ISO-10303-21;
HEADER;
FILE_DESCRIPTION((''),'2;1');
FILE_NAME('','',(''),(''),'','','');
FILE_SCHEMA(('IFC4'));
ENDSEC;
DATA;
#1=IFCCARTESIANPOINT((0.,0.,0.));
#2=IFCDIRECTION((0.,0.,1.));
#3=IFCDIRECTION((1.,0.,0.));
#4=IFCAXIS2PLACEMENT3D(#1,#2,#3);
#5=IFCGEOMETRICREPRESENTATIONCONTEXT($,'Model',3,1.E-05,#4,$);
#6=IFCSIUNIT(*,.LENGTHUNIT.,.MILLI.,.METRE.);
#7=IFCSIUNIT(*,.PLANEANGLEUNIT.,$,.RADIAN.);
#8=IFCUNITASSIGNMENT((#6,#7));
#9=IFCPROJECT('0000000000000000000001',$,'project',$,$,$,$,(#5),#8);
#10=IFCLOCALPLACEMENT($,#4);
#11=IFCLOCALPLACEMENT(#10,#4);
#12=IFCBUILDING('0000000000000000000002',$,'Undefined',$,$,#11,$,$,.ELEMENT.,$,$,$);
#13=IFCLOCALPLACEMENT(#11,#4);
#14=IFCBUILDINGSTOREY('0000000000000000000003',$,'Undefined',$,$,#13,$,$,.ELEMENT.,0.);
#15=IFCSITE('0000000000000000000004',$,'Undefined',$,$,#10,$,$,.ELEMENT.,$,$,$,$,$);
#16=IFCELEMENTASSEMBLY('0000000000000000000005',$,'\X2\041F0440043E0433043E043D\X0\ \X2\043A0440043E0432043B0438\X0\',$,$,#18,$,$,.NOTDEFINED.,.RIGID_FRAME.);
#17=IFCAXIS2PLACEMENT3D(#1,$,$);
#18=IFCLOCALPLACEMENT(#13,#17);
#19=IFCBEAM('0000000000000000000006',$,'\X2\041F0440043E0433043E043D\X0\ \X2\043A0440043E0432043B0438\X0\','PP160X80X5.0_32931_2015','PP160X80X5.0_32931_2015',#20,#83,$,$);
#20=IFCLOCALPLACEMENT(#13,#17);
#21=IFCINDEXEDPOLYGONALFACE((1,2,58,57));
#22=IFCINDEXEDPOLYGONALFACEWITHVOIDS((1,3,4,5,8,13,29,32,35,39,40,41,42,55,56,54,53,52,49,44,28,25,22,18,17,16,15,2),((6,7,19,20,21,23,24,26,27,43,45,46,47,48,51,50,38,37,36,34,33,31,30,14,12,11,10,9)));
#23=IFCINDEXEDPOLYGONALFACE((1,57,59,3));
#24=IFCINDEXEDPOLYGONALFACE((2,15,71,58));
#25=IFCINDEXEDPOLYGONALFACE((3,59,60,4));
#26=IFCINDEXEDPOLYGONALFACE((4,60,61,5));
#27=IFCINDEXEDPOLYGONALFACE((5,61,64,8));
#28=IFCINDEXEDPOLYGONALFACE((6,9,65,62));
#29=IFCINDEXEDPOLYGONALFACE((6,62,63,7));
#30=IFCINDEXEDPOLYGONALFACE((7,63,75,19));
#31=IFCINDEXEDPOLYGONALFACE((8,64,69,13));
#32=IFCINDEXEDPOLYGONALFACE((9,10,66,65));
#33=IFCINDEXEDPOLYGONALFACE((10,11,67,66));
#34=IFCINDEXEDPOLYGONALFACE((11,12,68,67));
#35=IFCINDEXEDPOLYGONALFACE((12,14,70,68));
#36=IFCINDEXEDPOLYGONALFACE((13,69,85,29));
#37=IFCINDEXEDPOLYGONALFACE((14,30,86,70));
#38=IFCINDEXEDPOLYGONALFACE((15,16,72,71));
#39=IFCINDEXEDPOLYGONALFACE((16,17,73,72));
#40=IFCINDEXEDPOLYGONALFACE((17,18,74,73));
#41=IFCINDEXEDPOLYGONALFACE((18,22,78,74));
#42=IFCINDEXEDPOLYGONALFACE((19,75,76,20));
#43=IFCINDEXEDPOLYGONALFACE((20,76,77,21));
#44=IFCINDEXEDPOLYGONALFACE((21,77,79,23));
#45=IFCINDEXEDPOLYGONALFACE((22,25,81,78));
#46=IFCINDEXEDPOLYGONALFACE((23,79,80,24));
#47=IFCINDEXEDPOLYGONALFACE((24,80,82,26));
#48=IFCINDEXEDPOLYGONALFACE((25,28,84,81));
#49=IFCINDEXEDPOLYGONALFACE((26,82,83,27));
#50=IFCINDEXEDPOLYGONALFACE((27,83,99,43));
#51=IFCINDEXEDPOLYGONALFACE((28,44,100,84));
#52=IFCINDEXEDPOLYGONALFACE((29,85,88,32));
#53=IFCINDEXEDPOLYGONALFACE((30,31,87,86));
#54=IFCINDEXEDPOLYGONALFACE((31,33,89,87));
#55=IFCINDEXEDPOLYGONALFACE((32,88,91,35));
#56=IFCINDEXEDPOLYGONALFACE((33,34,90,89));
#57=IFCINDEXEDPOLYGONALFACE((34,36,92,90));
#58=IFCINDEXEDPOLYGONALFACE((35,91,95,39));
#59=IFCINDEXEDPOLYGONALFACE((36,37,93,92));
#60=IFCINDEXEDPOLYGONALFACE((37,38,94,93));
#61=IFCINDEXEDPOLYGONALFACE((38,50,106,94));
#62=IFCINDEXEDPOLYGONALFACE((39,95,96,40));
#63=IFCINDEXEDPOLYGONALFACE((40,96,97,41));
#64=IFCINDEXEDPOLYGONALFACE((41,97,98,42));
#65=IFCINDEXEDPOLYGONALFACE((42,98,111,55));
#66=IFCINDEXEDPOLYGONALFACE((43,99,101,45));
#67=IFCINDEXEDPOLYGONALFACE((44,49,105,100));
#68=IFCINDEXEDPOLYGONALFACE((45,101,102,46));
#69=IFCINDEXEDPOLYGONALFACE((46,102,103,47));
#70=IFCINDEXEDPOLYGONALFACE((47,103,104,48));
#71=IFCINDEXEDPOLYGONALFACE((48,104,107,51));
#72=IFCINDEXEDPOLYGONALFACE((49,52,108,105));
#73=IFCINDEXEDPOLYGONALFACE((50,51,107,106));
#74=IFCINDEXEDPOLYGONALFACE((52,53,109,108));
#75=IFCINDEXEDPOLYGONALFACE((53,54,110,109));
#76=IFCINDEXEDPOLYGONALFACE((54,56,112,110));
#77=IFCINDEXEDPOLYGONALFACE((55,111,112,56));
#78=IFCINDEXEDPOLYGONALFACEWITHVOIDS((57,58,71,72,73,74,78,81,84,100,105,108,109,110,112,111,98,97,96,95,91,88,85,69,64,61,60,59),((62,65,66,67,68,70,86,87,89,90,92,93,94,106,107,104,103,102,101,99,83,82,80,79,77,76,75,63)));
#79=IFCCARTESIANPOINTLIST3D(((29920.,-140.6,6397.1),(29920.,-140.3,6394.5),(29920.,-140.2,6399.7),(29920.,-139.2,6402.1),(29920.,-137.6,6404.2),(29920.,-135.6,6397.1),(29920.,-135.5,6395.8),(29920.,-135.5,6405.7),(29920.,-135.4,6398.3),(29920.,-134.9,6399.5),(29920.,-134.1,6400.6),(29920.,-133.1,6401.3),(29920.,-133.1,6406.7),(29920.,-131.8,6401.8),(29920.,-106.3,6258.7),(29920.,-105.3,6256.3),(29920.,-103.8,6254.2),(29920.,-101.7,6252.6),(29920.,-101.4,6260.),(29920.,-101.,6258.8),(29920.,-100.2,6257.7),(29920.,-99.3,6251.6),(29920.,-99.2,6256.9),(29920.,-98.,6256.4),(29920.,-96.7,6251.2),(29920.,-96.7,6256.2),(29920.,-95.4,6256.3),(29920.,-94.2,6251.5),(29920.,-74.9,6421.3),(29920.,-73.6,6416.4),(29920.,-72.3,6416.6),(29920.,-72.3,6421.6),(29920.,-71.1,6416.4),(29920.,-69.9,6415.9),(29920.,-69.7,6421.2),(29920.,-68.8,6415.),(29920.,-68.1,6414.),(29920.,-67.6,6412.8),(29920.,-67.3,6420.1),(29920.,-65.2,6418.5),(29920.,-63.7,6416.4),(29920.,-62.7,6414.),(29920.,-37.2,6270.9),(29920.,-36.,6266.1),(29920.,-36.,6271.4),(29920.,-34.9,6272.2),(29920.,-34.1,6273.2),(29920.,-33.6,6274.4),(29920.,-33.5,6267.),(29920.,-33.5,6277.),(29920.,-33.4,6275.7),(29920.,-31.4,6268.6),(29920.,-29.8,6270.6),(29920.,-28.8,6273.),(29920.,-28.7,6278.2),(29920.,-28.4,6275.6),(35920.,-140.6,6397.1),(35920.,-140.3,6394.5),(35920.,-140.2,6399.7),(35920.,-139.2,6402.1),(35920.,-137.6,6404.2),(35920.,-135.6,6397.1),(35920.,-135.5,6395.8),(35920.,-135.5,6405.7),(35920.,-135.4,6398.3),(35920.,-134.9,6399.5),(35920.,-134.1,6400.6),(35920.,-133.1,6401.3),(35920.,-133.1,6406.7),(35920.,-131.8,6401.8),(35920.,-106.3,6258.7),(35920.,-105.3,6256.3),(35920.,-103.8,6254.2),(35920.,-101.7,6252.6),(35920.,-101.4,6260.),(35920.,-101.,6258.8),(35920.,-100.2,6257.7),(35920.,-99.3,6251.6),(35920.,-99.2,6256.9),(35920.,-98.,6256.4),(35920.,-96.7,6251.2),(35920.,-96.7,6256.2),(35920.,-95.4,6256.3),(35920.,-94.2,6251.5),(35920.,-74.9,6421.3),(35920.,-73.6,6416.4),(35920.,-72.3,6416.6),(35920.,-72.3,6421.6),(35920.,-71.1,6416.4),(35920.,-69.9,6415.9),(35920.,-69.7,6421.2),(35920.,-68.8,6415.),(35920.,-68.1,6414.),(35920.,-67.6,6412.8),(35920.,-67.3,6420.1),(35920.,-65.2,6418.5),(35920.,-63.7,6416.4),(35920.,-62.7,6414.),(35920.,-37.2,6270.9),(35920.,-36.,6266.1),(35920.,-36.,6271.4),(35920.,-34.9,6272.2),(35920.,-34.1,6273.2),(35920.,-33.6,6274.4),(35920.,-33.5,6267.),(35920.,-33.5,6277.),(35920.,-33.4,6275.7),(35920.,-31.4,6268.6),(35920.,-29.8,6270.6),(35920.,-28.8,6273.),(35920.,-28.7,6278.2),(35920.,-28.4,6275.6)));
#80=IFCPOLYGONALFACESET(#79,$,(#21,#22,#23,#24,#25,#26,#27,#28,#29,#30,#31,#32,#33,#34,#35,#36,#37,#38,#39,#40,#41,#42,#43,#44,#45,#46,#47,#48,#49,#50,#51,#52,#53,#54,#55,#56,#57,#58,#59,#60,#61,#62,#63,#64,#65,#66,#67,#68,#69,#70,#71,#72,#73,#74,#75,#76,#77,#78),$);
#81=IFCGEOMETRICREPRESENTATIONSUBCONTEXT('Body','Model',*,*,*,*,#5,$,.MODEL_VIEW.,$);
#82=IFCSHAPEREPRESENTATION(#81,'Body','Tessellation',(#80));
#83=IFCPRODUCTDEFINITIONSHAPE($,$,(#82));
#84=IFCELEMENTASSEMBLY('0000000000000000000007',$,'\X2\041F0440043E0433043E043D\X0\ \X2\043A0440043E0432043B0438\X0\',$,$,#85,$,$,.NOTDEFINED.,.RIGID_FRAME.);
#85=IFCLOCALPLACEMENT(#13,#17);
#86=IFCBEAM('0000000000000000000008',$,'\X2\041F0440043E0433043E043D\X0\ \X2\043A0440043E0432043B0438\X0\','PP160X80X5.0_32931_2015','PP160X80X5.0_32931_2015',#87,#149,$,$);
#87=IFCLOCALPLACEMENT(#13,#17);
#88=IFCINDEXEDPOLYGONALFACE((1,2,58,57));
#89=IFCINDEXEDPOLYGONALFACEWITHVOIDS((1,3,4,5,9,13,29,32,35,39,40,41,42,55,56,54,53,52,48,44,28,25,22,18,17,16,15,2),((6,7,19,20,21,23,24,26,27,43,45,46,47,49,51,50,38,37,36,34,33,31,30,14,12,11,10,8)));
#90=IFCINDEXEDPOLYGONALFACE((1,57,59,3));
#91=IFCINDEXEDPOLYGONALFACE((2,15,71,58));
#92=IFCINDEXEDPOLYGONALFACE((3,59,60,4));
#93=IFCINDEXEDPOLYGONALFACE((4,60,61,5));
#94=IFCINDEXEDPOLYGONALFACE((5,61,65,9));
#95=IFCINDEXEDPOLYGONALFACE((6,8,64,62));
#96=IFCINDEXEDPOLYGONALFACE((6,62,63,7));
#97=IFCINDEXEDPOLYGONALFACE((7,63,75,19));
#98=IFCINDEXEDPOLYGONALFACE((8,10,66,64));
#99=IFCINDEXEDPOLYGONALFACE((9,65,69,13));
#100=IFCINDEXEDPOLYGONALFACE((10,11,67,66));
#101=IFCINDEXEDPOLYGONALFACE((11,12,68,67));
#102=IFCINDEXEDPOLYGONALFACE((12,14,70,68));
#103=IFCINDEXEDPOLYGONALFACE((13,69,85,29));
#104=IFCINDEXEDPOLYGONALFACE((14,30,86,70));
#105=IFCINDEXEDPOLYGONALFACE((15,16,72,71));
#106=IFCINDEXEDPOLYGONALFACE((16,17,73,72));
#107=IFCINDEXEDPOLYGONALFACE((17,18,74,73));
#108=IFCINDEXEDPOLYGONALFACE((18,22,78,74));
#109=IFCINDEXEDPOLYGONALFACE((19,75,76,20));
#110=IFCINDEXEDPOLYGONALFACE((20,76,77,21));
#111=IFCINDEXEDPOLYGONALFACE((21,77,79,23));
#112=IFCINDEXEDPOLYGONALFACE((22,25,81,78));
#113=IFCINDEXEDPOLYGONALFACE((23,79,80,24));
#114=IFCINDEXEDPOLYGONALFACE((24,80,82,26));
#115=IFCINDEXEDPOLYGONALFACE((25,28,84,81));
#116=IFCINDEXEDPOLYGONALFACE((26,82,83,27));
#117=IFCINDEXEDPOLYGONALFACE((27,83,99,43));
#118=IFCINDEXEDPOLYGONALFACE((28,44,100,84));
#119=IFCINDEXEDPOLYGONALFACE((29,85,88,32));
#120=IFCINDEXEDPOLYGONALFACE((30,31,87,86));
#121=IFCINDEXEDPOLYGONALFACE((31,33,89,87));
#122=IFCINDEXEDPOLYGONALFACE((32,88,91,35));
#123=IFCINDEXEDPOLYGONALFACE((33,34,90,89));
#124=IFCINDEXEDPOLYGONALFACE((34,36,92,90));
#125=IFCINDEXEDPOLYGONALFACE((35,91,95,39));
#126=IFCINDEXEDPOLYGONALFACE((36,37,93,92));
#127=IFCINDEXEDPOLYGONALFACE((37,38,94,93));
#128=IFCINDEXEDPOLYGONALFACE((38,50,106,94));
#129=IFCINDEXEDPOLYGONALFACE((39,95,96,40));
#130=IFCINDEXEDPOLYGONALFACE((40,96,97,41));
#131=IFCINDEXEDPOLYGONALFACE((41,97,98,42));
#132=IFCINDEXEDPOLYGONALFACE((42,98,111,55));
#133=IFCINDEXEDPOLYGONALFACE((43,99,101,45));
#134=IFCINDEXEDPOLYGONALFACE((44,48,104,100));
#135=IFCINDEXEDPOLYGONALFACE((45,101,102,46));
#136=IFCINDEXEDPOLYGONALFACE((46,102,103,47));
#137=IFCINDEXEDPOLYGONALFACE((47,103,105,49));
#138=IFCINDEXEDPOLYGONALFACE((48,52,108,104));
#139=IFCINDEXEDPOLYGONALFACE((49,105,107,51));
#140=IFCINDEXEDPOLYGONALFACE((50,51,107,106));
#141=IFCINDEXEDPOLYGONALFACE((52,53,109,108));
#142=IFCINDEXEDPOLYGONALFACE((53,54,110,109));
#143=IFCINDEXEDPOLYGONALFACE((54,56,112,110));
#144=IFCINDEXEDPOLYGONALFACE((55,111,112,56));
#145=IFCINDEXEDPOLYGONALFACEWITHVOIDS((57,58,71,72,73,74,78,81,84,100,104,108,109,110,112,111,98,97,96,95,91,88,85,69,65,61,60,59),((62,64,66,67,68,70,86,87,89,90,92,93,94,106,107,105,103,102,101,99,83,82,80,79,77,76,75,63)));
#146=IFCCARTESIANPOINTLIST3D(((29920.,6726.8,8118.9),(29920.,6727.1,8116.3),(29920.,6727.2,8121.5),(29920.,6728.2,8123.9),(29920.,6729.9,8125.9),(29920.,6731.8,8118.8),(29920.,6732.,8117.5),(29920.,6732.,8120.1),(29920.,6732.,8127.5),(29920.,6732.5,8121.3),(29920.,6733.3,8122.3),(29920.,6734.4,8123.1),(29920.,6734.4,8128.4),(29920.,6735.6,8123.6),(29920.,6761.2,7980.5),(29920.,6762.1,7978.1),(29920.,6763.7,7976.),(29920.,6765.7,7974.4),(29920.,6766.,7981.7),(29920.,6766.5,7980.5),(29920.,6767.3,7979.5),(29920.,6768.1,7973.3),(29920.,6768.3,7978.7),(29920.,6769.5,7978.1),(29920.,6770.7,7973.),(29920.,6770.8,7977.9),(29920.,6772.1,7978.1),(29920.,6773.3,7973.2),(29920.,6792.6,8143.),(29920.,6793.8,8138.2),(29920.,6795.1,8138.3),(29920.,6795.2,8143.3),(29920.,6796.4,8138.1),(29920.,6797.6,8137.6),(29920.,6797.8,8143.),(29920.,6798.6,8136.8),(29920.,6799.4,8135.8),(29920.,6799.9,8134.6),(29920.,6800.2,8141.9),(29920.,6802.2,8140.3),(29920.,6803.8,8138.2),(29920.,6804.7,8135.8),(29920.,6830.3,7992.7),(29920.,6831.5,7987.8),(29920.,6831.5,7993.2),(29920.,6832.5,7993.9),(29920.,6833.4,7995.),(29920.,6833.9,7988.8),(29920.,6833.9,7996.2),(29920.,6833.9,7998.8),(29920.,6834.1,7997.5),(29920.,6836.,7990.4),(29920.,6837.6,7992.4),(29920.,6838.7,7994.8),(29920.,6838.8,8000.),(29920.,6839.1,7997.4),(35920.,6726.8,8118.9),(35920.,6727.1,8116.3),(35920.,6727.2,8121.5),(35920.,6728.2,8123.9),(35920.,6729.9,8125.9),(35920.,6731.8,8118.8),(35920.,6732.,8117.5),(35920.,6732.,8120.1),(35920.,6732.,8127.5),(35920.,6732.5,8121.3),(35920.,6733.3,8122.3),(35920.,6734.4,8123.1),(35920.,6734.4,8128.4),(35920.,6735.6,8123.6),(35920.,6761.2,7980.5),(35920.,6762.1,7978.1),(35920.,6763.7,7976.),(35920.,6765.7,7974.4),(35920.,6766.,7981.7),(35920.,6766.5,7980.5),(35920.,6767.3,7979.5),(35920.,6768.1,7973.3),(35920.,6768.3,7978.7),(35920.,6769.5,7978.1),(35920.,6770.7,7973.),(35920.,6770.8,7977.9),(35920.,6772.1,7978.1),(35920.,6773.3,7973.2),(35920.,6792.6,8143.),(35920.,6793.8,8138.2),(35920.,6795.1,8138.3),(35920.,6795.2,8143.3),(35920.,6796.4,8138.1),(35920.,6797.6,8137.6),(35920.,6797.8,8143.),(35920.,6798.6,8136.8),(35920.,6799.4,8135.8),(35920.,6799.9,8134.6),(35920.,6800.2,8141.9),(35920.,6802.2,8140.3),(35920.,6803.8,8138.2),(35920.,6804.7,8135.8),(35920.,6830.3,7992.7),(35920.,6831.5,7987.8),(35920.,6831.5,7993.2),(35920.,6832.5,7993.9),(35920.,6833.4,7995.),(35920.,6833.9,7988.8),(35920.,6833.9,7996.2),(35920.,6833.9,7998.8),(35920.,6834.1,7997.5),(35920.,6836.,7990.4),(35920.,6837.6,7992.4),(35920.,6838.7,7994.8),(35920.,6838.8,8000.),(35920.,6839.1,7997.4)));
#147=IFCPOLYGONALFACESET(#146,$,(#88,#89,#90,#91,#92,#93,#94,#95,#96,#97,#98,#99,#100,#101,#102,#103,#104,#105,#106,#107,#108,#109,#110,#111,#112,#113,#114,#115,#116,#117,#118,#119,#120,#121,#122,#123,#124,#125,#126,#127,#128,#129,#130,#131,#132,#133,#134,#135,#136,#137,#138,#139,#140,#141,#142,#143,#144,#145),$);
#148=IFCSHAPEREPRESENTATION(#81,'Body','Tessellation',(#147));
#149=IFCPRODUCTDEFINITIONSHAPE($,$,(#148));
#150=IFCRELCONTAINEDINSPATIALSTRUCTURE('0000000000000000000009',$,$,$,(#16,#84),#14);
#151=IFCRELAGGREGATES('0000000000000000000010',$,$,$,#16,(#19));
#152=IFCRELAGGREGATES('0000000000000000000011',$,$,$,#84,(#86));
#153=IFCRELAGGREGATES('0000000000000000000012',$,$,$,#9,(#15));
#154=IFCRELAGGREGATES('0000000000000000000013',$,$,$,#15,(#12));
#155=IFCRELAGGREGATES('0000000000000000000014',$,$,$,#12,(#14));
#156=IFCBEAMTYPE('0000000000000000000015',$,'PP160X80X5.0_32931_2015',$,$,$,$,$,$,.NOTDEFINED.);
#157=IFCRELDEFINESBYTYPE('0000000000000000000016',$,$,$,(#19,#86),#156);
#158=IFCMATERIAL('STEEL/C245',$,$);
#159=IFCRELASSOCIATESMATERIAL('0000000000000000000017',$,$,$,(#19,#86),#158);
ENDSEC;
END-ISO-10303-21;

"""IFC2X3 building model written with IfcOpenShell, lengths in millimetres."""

from ifc_helpers import new_model, si_unit, frame, origin_with_axes, origin_2d_with_axis, place, context, subcontext, project, spatial, hollow_rectangle, extrude, material, type_object, element, aggregate, save


model = new_model("IFC2X3")

# Units and contexts
model_context = context("Model", 3, precision=1e-05, world=origin_with_axes())
body_context = subcontext(model_context, "Body", "Model", "MODEL_VIEW")
ifc_project = project(units=[si_unit("LENGTHUNIT", "METRE", prefix="MILLI"), si_unit("PLANEANGLEUNIT", "RADIAN")], contexts=[model_context])

# Site, building, storey
site_placement = place(None, origin_with_axes())
site = spatial("IfcSite", under=ifc_project, at=site_placement, Name="Undefined", CompositionType="ELEMENT")
building_placement = place(site_placement, origin_with_axes())
building = spatial("IfcBuilding", under=site, at=building_placement, Name="Undefined", CompositionType="ELEMENT")
storey_placement = place(building_placement, origin_with_axes())
storey = spatial("IfcBuildingStorey", under=building, at=storey_placement, Name="Undefined", CompositionType="ELEMENT", Elevation=0.0)

# Shared definitions
ifc_material = material(Name="STEEL/C245")

# Element assemblies, beams
assembly_1_placement = place(storey_placement, origin_with_axes())
assembly_1 = element("IfcElementAssembly", 1, at=assembly_1_placement, inside=storey, Name="Прогон кровли", AssemblyPlace="NOTDEFINED", PredefinedType="RIGID_FRAME")
beam_type_1 = type_object("IfcBeamType", Name="PP160X80X5.0_32931_2015", PredefinedType="NOTDEFINED")
beam_1_placement = place(assembly_1_placement, frame((29920.0, -84.5, 6336.4), z_axis=(0.0, -0.243188, 0.969979), x_axis=(1.0, 0.0, 0.0)))
beam_1 = element("IfcBeam", 2, at=beam_1_placement, type_object=beam_type_1, material=ifc_material, Name="Прогон кровли", Description="PP160X80X5.0_32931_2015", ObjectType="PP160X80X5.0_32931_2015", context=body_context, shape_type="SweptSolid", body=[
    extrude(hollow_rectangle(XDim=80.0, YDim=160.0, WallThickness=5.0, InnerFilletRadius=5.0, OuterFilletRadius=10.0, at=origin_2d_with_axis()), frame((6000.0, 0.0, 0.0), z_axis=(-1.0, 0.0, 0.0), x_axis=(0.0, -1.0, 0.0)), (0.0, 0.0, 1.0), 6000.0),
])
aggregate(assembly_1, [beam_1])
assembly_2_placement = place(storey_placement, origin_with_axes())
assembly_2 = element("IfcElementAssembly", 3, at=assembly_2_placement, inside=storey, Name="Прогон кровли", AssemblyPlace="NOTDEFINED", PredefinedType="RIGID_FRAME")
beam_2_placement = place(assembly_2_placement, frame((29920.0, 6782.9, 8058.1), z_axis=(0.0, -0.243188, 0.969979), x_axis=(1.0, 0.0, 0.0)))
beam_2 = element("IfcBeam", 4, at=beam_2_placement, type_object=beam_type_1, material=ifc_material, Name="Прогон кровли", Description="PP160X80X5.0_32931_2015", ObjectType="PP160X80X5.0_32931_2015", context=body_context, shape_type="SweptSolid", body=[
    extrude(hollow_rectangle(XDim=80.0, YDim=160.0, WallThickness=5.0, InnerFilletRadius=5.0, OuterFilletRadius=10.0, at=origin_2d_with_axis()), frame((6000.0, 0.0, 0.0), z_axis=(-1.0, 0.0, 0.0), x_axis=(0.0, -1.0, 0.0)), (0.0, 0.0, 1.0), 6000.0),
])
aggregate(assembly_2, [beam_2])

save(model, "model.ifc")
